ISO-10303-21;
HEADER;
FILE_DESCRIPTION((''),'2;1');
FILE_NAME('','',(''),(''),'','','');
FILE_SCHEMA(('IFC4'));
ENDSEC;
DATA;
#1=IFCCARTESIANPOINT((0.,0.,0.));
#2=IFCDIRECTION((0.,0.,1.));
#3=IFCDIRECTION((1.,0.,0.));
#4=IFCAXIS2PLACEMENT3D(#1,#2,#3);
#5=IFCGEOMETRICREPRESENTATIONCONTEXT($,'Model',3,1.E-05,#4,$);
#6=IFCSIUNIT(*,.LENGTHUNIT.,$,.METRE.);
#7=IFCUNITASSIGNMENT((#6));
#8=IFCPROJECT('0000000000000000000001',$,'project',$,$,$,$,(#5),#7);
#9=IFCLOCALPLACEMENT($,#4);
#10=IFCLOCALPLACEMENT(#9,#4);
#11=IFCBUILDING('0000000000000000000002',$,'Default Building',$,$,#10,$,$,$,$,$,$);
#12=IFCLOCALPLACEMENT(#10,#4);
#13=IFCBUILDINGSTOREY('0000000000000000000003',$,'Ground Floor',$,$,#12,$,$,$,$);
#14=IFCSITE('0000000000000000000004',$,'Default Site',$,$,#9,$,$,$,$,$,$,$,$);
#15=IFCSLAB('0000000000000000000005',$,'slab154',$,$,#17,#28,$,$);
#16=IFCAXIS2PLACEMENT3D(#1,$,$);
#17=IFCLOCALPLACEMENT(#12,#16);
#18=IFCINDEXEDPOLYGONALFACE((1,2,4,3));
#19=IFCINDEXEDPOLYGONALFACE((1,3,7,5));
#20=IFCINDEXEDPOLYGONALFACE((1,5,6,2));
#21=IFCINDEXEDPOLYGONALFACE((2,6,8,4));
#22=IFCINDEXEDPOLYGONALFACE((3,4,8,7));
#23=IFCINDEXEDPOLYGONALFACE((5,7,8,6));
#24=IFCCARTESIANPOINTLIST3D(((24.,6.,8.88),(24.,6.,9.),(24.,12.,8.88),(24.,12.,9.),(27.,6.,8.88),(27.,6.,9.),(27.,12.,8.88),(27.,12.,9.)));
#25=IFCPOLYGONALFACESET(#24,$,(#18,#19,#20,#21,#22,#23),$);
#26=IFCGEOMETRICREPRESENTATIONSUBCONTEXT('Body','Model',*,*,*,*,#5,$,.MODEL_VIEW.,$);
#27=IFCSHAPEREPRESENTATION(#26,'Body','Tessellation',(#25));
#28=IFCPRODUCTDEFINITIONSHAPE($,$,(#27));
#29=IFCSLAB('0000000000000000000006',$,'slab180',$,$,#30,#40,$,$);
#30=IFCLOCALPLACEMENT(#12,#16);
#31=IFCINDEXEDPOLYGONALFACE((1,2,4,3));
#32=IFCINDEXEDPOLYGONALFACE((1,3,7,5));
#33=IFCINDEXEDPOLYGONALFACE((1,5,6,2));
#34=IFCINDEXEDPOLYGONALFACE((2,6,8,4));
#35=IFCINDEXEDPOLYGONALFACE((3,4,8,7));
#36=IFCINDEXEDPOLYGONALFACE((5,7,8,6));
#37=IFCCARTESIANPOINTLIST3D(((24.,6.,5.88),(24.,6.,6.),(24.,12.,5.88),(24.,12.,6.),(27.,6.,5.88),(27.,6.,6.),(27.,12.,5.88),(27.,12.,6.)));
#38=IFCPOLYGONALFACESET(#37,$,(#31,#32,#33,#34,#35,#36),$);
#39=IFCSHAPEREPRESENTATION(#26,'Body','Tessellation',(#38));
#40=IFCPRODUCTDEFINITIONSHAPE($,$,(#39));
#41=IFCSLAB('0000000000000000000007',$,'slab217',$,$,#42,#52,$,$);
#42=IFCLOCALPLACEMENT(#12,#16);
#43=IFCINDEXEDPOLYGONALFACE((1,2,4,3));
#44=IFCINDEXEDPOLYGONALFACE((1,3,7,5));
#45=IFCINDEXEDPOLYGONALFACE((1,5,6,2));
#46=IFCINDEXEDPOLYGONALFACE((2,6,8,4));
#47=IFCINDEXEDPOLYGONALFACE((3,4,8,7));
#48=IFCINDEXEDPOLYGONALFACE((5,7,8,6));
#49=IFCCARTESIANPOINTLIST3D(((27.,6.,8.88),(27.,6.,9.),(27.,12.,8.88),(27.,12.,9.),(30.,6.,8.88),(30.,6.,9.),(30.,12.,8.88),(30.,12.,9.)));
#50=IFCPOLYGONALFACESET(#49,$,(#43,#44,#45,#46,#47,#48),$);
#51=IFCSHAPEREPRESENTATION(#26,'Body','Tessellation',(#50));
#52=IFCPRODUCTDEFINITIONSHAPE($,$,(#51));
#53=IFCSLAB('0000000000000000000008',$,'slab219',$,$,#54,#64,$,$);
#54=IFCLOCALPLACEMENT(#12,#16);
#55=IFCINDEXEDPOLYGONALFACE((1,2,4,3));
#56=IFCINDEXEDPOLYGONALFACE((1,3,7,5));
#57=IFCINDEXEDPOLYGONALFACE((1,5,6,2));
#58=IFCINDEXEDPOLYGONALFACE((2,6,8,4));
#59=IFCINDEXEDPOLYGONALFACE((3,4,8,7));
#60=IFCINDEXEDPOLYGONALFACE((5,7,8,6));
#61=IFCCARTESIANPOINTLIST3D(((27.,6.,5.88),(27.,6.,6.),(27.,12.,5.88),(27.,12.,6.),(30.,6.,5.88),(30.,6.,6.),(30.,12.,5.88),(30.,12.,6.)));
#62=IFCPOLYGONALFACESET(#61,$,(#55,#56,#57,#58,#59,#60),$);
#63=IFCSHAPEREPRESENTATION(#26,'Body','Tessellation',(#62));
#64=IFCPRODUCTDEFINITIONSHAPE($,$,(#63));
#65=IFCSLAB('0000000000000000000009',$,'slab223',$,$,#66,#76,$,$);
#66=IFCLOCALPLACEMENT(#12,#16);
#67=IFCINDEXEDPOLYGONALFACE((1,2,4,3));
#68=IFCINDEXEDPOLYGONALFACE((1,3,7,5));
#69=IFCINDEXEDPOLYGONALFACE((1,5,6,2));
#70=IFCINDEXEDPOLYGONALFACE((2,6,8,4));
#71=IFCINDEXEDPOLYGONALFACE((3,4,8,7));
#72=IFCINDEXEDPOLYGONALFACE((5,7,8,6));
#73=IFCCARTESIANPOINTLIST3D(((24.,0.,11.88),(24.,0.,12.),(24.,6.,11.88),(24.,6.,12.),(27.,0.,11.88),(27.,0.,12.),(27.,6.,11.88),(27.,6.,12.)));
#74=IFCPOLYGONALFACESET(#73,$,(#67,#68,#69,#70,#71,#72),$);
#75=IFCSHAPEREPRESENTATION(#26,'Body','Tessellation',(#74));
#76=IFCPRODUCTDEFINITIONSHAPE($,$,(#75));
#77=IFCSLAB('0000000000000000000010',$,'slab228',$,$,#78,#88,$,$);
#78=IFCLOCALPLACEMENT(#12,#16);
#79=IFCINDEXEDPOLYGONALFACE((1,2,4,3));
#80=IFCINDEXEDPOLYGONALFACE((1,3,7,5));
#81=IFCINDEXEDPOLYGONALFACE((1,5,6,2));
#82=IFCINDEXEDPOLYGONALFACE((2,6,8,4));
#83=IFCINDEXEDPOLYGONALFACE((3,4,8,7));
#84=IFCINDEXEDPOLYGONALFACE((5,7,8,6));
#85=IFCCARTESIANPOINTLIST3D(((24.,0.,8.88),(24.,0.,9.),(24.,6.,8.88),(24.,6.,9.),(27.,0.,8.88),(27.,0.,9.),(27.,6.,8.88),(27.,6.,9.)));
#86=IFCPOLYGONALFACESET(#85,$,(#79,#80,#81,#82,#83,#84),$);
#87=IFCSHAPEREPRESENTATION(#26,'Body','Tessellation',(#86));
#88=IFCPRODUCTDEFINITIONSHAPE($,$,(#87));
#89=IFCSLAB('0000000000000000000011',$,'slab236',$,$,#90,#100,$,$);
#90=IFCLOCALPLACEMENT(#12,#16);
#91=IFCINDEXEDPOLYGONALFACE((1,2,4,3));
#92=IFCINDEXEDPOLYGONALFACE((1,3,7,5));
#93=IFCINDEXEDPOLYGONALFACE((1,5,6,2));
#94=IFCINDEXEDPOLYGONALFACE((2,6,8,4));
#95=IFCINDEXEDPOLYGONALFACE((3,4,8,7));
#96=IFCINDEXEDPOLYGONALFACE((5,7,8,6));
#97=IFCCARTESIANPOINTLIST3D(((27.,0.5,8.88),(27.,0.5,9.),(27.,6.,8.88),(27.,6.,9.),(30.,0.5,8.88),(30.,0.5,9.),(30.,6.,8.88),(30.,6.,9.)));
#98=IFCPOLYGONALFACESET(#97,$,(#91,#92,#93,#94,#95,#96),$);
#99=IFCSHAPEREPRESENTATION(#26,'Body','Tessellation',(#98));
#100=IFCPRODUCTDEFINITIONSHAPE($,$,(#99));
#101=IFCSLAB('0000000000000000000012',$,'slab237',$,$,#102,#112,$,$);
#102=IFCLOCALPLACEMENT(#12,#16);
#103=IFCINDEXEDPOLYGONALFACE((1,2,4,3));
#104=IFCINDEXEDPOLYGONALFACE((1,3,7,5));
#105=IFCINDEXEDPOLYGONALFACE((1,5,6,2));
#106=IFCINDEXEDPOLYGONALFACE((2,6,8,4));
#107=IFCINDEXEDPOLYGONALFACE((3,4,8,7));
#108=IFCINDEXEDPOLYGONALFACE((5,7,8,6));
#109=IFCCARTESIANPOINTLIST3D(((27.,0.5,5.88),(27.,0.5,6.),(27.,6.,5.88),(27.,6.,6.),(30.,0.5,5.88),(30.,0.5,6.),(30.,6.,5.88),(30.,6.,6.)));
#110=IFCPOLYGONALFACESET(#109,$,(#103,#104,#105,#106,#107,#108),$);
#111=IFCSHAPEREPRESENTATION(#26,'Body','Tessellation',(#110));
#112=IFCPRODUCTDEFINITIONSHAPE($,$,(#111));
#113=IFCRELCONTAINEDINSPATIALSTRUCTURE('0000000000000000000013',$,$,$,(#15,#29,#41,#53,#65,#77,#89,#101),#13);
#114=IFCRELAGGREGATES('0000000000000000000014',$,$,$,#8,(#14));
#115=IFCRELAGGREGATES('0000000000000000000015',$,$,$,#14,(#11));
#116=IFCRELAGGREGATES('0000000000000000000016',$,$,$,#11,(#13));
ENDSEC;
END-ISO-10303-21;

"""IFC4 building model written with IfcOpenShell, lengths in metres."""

from ifc_helpers import new_model, si_unit, frame, origin_with_axes, place, context, subcontext, project, spatial, indexed_curve, outline, extrude, element, save


model = new_model("IFC4")

# Units and contexts
model_context = context("Model", 3, precision=1e-05, world=origin_with_axes())
body_context = subcontext(model_context, "Body", "Model", "MODEL_VIEW")
ifc_project = project(units=[si_unit("LENGTHUNIT", "METRE")], contexts=[model_context])

# Site, building, storey
site_placement = place(None, origin_with_axes())
site = spatial("IfcSite", under=ifc_project, at=site_placement, Name="Default Site")
building_placement = place(site_placement, origin_with_axes())
building = spatial("IfcBuilding", under=site, at=building_placement, Name="Default Building")
storey_placement = place(building_placement, origin_with_axes())
storey = spatial("IfcBuildingStorey", under=building, at=storey_placement, Name="Ground Floor")

# Slabs
for number, where, z_axis, x_axis, name in (
    (1, (24.0, 6.0, 8.88), (0.0, 0.0, 1.0), (1.0, 0.0, 0.0), "slab154"),
    (2, (24.0, 6.0, 5.88), (0.0, 0.0, 1.0), (1.0, 0.0, 0.0), "slab180"),
    (3, (27.0, 6.0, 8.88), (0.0, 0.0, 1.0), (1.0, 0.0, 0.0), "slab217"),
    (4, (27.0, 6.0, 5.88), (0.0, 0.0, 1.0), (1.0, 0.0, 0.0), "slab219"),
    (5, (24.0, 0.0, 11.88), (0.0, 0.0, 1.0), (1.0, 0.0, 0.0), "slab223"),
    (6, (24.0, 0.0, 8.88), (0.0, 0.0, 1.0), (1.0, 0.0, 0.0), "slab228"),
):
    element("IfcSlab", number, at=place(storey_placement, frame(where, z_axis=z_axis, x_axis=x_axis)), inside=storey, Name=name, context=body_context, shape_type="SweptSolid", body=[
        extrude(outline(indexed_curve([(0.0, 0.0), (0.0, 6.0), (3.0, 6.0), (3.0, 0.0), (0.0, 0.0)], self_intersect=False)), origin_with_axes(), (0.0, 0.0, 1.0), 0.12),
    ])
for number, where, z_axis, x_axis, name in (
    (7, (27.0, 0.5, 8.88), (0.0, 0.0, 1.0), (1.0, 0.0, 0.0), "slab236"),
    (8, (27.0, 0.5, 5.88), (0.0, 0.0, 1.0), (1.0, 0.0, 0.0), "slab237"),
):
    element("IfcSlab", number, at=place(storey_placement, frame(where, z_axis=z_axis, x_axis=x_axis)), inside=storey, Name=name, context=body_context, shape_type="SweptSolid", body=[
        extrude(outline(indexed_curve([(0.0, 0.0), (0.0, 5.5), (3.0, 5.5), (3.0, 0.0), (0.0, 0.0)], self_intersect=False)), origin_with_axes(), (0.0, 0.0, 1.0), 0.12),
    ])

save(model, "model.ifc")
